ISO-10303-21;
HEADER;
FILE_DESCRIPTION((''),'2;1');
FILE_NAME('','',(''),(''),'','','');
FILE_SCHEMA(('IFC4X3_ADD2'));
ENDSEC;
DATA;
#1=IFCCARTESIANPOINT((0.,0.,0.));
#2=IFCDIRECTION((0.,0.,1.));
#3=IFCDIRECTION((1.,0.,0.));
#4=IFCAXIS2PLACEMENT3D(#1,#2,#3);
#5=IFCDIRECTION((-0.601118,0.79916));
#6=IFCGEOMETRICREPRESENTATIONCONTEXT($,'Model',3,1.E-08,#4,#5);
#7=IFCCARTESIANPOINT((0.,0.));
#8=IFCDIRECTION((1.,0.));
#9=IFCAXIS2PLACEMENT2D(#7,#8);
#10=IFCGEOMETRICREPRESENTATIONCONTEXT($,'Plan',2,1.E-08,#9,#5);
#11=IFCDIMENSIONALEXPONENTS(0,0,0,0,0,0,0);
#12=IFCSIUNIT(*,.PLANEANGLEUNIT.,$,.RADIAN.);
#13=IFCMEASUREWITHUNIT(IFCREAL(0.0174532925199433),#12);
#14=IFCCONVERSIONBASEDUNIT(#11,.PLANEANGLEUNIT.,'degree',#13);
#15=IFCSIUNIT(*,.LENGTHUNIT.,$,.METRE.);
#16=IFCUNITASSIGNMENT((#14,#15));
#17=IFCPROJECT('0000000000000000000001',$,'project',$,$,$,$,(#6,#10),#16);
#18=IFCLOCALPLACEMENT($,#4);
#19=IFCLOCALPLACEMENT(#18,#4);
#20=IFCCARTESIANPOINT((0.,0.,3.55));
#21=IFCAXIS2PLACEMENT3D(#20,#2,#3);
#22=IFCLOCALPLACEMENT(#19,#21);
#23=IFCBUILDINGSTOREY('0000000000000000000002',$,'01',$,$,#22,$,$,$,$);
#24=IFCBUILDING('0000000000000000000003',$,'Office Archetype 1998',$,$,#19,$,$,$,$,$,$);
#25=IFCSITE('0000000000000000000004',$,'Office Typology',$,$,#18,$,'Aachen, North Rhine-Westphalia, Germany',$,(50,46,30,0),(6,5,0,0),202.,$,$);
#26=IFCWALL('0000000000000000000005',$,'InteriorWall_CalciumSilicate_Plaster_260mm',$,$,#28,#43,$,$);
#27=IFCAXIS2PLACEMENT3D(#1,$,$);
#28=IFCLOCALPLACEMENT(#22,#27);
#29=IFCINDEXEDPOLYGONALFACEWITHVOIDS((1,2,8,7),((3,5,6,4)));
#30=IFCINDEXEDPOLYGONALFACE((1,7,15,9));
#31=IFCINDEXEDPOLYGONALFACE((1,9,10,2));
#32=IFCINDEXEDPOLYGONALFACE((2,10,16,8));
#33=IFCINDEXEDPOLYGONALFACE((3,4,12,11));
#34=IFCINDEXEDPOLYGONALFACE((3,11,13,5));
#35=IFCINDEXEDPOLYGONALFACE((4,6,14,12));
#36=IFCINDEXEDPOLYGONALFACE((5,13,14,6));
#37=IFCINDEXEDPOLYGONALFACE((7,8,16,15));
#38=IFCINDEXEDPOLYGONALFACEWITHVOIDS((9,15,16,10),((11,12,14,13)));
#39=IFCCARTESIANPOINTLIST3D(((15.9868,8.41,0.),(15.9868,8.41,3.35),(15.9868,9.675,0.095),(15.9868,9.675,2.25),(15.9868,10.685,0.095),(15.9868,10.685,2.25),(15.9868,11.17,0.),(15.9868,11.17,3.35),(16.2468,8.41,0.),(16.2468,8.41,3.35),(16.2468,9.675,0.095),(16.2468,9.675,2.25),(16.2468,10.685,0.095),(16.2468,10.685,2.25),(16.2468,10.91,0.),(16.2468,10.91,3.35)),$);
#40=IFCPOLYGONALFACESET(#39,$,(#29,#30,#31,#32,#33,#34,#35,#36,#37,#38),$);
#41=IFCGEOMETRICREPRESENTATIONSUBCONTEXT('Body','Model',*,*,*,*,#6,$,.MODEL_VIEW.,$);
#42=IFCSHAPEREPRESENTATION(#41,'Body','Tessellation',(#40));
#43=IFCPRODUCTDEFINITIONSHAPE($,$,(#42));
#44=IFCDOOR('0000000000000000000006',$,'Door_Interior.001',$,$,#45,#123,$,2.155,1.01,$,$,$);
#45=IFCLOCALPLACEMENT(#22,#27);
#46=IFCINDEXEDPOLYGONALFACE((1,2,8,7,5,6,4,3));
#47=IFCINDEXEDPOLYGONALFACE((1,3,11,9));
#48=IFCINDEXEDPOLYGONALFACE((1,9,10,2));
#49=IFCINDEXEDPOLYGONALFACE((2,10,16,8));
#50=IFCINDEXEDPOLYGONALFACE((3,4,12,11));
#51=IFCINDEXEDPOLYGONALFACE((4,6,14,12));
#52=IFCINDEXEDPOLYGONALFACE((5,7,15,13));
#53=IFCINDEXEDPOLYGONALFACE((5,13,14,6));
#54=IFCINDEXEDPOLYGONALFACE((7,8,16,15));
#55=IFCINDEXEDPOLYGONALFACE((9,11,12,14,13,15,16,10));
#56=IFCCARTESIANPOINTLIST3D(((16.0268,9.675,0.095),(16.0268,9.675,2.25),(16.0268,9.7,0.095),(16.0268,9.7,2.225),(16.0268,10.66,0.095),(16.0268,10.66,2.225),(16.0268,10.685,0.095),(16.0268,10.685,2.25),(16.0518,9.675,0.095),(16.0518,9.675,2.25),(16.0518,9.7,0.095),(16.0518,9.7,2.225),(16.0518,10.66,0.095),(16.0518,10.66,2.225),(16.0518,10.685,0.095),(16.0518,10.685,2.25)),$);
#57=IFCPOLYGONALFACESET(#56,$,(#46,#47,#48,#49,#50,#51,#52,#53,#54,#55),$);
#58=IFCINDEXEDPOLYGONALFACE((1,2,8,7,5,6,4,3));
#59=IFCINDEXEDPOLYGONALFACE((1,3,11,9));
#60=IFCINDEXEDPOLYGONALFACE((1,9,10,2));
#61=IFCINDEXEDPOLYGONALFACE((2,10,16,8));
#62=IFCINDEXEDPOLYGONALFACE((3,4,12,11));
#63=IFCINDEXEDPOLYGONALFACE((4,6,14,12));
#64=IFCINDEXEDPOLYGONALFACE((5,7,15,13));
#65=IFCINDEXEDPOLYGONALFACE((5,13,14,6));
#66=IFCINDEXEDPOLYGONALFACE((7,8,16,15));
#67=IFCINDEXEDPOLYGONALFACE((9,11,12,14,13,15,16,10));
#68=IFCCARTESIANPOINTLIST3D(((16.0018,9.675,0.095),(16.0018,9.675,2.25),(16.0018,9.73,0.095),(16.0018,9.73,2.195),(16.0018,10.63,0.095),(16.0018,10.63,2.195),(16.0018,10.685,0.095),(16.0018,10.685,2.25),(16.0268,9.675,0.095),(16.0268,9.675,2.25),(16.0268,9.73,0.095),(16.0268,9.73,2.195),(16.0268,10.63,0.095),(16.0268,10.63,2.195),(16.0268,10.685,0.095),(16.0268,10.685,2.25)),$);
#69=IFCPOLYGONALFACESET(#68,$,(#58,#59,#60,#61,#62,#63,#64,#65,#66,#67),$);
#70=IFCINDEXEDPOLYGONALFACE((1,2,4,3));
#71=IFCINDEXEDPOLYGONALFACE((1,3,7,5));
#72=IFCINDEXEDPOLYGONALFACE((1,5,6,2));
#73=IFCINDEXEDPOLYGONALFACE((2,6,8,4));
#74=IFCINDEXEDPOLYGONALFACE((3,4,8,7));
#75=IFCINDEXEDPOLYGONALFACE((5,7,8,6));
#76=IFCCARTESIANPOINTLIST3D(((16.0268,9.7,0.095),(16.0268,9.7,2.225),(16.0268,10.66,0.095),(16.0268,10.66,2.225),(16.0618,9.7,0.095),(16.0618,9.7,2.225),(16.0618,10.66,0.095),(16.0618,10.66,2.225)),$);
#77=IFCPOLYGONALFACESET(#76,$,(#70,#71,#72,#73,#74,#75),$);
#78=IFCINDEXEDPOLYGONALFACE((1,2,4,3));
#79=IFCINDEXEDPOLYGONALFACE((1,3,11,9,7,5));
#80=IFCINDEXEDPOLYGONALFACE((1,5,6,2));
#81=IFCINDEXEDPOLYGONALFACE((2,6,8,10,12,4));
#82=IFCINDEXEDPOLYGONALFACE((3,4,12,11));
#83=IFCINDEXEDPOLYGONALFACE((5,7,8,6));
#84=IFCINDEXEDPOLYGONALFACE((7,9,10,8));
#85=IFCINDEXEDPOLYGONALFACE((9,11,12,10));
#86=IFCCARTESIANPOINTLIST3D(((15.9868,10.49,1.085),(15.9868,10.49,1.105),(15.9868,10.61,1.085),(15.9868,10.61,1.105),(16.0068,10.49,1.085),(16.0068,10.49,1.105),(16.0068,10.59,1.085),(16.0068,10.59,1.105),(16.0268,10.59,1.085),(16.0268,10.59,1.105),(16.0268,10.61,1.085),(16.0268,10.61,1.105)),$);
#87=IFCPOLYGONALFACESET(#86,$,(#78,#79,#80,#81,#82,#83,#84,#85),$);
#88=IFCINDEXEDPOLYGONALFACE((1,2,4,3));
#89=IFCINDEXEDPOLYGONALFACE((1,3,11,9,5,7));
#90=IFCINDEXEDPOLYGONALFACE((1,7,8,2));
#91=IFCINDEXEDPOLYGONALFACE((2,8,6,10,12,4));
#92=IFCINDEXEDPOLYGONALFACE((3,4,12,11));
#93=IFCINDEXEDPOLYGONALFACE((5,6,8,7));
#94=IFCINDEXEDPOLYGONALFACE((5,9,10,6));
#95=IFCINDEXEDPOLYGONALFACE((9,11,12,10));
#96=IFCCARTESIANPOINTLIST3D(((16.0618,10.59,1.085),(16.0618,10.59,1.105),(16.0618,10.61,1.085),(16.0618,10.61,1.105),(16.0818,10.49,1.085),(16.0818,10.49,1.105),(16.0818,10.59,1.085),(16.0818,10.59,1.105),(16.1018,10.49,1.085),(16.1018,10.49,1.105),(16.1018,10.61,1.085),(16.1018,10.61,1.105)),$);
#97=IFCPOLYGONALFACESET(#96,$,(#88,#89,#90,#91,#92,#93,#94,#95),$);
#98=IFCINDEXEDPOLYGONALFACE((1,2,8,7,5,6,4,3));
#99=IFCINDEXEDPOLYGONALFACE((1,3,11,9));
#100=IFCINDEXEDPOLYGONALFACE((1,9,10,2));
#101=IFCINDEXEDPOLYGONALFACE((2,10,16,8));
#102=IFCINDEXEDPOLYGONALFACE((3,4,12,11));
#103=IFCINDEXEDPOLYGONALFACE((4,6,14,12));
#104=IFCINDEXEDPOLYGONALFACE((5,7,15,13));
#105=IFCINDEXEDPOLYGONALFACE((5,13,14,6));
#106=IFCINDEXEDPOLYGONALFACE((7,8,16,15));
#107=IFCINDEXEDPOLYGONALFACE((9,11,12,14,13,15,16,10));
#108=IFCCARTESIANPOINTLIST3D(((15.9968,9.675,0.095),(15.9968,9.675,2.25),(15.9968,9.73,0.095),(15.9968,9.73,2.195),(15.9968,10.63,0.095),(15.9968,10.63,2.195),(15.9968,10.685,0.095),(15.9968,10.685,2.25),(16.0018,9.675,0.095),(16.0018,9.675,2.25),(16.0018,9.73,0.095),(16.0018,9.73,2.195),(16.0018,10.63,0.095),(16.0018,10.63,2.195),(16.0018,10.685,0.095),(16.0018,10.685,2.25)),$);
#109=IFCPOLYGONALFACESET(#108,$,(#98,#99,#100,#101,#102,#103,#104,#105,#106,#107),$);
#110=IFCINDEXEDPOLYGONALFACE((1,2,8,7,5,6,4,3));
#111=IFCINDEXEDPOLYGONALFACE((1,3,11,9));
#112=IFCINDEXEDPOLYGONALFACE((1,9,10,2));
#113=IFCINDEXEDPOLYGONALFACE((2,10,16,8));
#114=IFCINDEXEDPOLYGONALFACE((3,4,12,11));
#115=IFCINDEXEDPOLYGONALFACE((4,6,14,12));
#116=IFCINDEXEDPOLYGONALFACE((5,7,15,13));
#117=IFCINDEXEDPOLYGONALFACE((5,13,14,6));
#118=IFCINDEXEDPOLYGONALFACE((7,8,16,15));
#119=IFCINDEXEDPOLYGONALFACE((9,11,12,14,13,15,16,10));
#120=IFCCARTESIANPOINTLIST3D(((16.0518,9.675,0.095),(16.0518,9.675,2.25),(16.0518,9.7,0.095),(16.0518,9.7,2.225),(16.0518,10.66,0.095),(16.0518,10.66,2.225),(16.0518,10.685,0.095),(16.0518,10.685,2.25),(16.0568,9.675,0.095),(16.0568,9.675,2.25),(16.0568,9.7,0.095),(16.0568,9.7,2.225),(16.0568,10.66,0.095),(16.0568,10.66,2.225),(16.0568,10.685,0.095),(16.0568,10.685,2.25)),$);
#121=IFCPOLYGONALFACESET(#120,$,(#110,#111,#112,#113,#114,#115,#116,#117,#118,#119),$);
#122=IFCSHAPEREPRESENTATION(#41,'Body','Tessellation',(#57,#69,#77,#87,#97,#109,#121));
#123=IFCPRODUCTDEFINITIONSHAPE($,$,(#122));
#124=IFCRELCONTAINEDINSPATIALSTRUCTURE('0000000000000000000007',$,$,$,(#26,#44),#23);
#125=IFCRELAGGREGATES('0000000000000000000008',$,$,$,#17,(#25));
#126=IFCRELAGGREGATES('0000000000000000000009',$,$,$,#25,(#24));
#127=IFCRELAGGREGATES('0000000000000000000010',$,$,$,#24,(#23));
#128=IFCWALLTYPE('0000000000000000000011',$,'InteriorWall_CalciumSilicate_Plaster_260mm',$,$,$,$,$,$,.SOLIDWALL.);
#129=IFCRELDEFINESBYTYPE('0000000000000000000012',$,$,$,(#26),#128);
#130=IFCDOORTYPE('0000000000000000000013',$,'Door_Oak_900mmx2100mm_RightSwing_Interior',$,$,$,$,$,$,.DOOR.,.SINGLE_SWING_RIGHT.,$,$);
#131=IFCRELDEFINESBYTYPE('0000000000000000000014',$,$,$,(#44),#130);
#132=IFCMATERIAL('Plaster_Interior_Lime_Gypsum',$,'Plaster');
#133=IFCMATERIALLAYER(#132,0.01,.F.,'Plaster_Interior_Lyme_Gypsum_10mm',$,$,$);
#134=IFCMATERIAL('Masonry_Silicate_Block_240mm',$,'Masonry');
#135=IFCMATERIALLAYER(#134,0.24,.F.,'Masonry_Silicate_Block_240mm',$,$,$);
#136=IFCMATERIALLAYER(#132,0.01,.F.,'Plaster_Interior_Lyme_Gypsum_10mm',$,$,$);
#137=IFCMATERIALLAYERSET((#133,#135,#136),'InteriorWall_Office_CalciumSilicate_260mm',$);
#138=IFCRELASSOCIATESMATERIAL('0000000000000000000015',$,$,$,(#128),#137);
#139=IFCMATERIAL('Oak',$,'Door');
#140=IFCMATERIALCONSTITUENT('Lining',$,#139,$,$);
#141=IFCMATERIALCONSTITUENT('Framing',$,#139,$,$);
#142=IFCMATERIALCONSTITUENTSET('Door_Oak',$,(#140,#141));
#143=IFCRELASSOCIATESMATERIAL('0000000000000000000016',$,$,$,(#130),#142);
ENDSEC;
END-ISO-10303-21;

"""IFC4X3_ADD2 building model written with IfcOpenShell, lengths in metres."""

from ifc_helpers import new_model, entity, si_unit, converted_unit, direction, frame, origin_with_axes, origin_2d_with_axis, place, context, subcontext, project, spatial, line, indexed_curve, outline, extrude, source, transform, mapped, material, layer, layer_set, constituent, constituent_set, type_object, type_shapes, element, fill, save


model = new_model("IFC4X3_ADD2")

# Units and contexts
model_context = context("Model", 3, precision=1e-08, world=origin_with_axes(), true_north=direction((-0.601118, 0.79916)))
plan_context = context("Plan", 2, precision=1e-08, world=origin_2d_with_axis(), true_north=direction((-0.601118, 0.79916)))
body_context = subcontext(model_context, "Body", "Model", "MODEL_VIEW")
ifc_project = project(units=[converted_unit("PLANEANGLEUNIT", "degree", entity("IfcReal", 0.0174532925199433), si_unit("PLANEANGLEUNIT", "RADIAN"), dimensions=[0, 0, 0, 0, 0, 0, 0]), si_unit("LENGTHUNIT", "METRE")], contexts=[model_context, plan_context])

# Site, building, storey
site_placement = place(None, origin_with_axes())
site = spatial("IfcSite", under=ifc_project, at=site_placement, Name="Office Typology", LongName="Aachen, North Rhine-Westphalia, Germany", RefLatitude=(50, 46, 30, 0), RefLongitude=(6, 5, 0, 0), RefElevation=202.0)
building_placement = place(site_placement, origin_with_axes())
building = spatial("IfcBuilding", under=site, at=building_placement, Name="Office Archetype 1998")
storey_placement = place(building_placement, frame((0.0, 0.0, 3.55), z_axis=(0.0, 0.0, 1.0), x_axis=(1.0, 0.0, 0.0)))
storey = spatial("IfcBuildingStorey", under=building, at=storey_placement, Name="01")

# Wall, opening, door
ifc_material_1 = material(Name="Plaster_Interior_Lime_Gypsum", Category="Plaster")
ifc_layer_1 = layer(ifc_material_1, 0.01, ventilated=False, Name="Plaster_Interior_Lyme_Gypsum_10mm")
ifc_material_2 = material(Name="Masonry_Silicate_Block_240mm", Category="Masonry")
ifc_layer_2 = layer(ifc_material_2, 0.24, ventilated=False, Name="Masonry_Silicate_Block_240mm")
ifc_layer_3 = layer(ifc_material_1, 0.01, ventilated=False, Name="Plaster_Interior_Lyme_Gypsum_10mm")
ifc_layer_set_1 = layer_set([ifc_layer_1, ifc_layer_2, ifc_layer_3], Name="InteriorWall_Office_CalciumSilicate_260mm")
wall_type_1 = type_object("IfcWallType", Name="InteriorWall_CalciumSilicate_Plaster_260mm", PredefinedType="SOLIDWALL", material=ifc_layer_set_1)
wall_1_placement = place(storey_placement, frame((15.9868, 11.17, 0.0), z_axis=(0.0, 0.0, 1.0), x_axis=(0.0, -1.0, 0.0)))
wall_1 = element("IfcWall", 1, at=wall_1_placement, inside=storey, type_object=wall_type_1, Name="InteriorWall_CalciumSilicate_Plaster_260mm", context=body_context, shape_type="SweptSolid", body=[
    extrude(outline(indexed_curve([(0.0, 0.0), (0.26, 0.26), (2.76, 0.26), (2.76, 0.0)], segments=[line(1, 2, 3, 4, 1)])), origin_with_axes(), (0.0, 0.0, 1.0), 3.35),
])
shared_shape_1 = source(origin_with_axes(), body_context, "Body", "SweptSolid", [
    extrude(outline(indexed_curve([(0.0, 2.155), (1.01, 2.155), (1.01, 0.0), (0.0, 0.0), (0.0, 2.155)])), frame((0.0, 0.0, 0.0), z_axis=(0.0, -1.0, 0.0), x_axis=(1.0, 0.0, 0.0)), (0.0, 0.0, -1.0), 0.26),
])
opening_1_placement = place(wall_1_placement, frame((0.485, 0.0, 0.095), z_axis=(0.0, 0.0, 1.0), x_axis=(1.0, 0.0, 0.0)))
opening_1 = element("IfcOpeningElement", 2, at=opening_1_placement, cuts=wall_1, PredefinedType="OPENING", context=body_context, shape_type="MappedRepresentation", body=[
    mapped(shared_shape_1, transform((0.0, 0.0, 0.0), x_axis=(1.0, 0.0, 0.0), y_axis=(0.0, 1.0, 0.0), z_axis=(0.0, 0.0, 1.0), scale=1.0)),
])
ifc_material_3 = material(Name="Oak", Category="Door")
ifc_constituent_1 = constituent(ifc_material_3, Name="Lining")
ifc_constituent_2 = constituent(ifc_material_3, Name="Framing")
ifc_constituent_set_1 = constituent_set(constituents=[ifc_constituent_1, ifc_constituent_2], Name="Door_Oak")
door_type = type_object("IfcDoorType", Name="Door_Oak_900mmx2100mm_RightSwing_Interior", OperationType="SINGLE_SWING_RIGHT", PredefinedType="DOOR", material=ifc_constituent_set_1)
shared_shape_2 = source(origin_with_axes(), body_context, "Body", "SweptSolid", [
    extrude(outline(indexed_curve([(0.0, 0.0), (0.0, 2.155), (1.01, 2.155), (1.01, 0.0), (0.985, 0.0), (0.985, 2.13), (0.025, 2.13), (0.025, 0.0)], segments=[line(1, 2, 3, 4, 5, 6, 7, 8, 1)])), frame((0.0, 0.025, 0.0), z_axis=(0.0, -1.0, 0.0), x_axis=(1.0, 0.0, 0.0)), (0.0, 0.0, -1.0), 0.025),
    extrude(outline(indexed_curve([(0.0, 0.0), (0.0, 2.155), (1.01, 2.155), (1.01, 0.0), (0.955, 0.0), (0.955, 2.1), (0.055, 2.1), (0.055, 0.0)], segments=[line(1, 2, 3, 4, 5, 6, 7, 8, 1)])), frame((0.0, 0.0, 0.0), z_axis=(0.0, -1.0, 0.0), x_axis=(1.0, 0.0, 0.0)), (0.0, 0.0, -1.0), 0.025),
    extrude(outline(indexed_curve([(0.0, 0.0), (0.96, 0.0), (0.96, 0.035), (0.0, 0.035)], segments=[line(1, 2, 3, 4, 1)])), frame((0.025, 0.025, 0.0), z_axis=(0.0, 0.0, 1.0), x_axis=(1.0, 0.0, 0.0)), (0.0, 0.0, 1.0), 2.13),
    extrude(outline(indexed_curve([(0.0, 0.0), (0.0, -0.04), (0.12, -0.04), (0.12, -0.02), (0.02, -0.02), (0.02, 0.0)], segments=[line(1, 2, 3, 4, 5, 6, 1)])), frame((0.075, 0.025, 0.99), z_axis=(0.0, 0.0, 1.0), x_axis=(1.0, 0.0, 0.0)), (0.0, 0.0, 1.0), 0.02),
    extrude(outline(indexed_curve([(0.0, 0.0), (0.0, 0.04), (0.12, 0.04), (0.12, 0.02), (0.02, 0.02), (0.02, 0.0)], segments=[line(1, 2, 3, 4, 5, 6, 1)])), frame((0.075, 0.06, 0.99), z_axis=(0.0, 0.0, 1.0), x_axis=(1.0, 0.0, 0.0)), (0.0, 0.0, 1.0), 0.02),
    extrude(outline(indexed_curve([(0.0, 0.0), (0.0, 2.155), (1.01, 2.155), (1.01, 0.0), (0.955, 0.0), (0.955, 2.1), (0.055, 2.1), (0.055, 0.0)], segments=[line(1, 2, 3, 4, 5, 6, 7, 8, 1)])), frame((0.0, -0.005, 0.0), z_axis=(0.0, -1.0, 0.0), x_axis=(1.0, 0.0, 0.0)), (0.0, 0.0, -1.0), 0.005),
    extrude(outline(indexed_curve([(0.0, 0.0), (0.0, 2.155), (1.01, 2.155), (1.01, 0.0), (0.985, 0.0), (0.985, 2.13), (0.025, 2.13), (0.025, 0.0)], segments=[line(1, 2, 3, 4, 5, 6, 7, 8, 1)])), frame((0.0, 0.05, 0.0), z_axis=(0.0, -1.0, 0.0), x_axis=(1.0, 0.0, 0.0)), (0.0, 0.0, -1.0), 0.005),
])
type_shapes(door_type, [shared_shape_2])
door_placement = place(opening_1_placement, frame((0.0, 0.015, 0.0), z_axis=(0.0, 0.0, 1.0), x_axis=(1.0, 0.0, 0.0)))
door = element("IfcDoor", 3, at=door_placement, inside=storey, type_object=door_type, Name="Door_Interior.001", OverallHeight=2.155, OverallWidth=1.01, context=body_context, shape_type="MappedRepresentation", body=[
    mapped(shared_shape_2, transform((0.0, 0.0, 0.0), x_axis=(1.0, 0.0, 0.0), y_axis=(0.0, 1.0, 0.0), z_axis=(0.0, 0.0, 1.0), scale=1.0)),
])
fill(opening_1, door)

save(model, "model.ifc")
